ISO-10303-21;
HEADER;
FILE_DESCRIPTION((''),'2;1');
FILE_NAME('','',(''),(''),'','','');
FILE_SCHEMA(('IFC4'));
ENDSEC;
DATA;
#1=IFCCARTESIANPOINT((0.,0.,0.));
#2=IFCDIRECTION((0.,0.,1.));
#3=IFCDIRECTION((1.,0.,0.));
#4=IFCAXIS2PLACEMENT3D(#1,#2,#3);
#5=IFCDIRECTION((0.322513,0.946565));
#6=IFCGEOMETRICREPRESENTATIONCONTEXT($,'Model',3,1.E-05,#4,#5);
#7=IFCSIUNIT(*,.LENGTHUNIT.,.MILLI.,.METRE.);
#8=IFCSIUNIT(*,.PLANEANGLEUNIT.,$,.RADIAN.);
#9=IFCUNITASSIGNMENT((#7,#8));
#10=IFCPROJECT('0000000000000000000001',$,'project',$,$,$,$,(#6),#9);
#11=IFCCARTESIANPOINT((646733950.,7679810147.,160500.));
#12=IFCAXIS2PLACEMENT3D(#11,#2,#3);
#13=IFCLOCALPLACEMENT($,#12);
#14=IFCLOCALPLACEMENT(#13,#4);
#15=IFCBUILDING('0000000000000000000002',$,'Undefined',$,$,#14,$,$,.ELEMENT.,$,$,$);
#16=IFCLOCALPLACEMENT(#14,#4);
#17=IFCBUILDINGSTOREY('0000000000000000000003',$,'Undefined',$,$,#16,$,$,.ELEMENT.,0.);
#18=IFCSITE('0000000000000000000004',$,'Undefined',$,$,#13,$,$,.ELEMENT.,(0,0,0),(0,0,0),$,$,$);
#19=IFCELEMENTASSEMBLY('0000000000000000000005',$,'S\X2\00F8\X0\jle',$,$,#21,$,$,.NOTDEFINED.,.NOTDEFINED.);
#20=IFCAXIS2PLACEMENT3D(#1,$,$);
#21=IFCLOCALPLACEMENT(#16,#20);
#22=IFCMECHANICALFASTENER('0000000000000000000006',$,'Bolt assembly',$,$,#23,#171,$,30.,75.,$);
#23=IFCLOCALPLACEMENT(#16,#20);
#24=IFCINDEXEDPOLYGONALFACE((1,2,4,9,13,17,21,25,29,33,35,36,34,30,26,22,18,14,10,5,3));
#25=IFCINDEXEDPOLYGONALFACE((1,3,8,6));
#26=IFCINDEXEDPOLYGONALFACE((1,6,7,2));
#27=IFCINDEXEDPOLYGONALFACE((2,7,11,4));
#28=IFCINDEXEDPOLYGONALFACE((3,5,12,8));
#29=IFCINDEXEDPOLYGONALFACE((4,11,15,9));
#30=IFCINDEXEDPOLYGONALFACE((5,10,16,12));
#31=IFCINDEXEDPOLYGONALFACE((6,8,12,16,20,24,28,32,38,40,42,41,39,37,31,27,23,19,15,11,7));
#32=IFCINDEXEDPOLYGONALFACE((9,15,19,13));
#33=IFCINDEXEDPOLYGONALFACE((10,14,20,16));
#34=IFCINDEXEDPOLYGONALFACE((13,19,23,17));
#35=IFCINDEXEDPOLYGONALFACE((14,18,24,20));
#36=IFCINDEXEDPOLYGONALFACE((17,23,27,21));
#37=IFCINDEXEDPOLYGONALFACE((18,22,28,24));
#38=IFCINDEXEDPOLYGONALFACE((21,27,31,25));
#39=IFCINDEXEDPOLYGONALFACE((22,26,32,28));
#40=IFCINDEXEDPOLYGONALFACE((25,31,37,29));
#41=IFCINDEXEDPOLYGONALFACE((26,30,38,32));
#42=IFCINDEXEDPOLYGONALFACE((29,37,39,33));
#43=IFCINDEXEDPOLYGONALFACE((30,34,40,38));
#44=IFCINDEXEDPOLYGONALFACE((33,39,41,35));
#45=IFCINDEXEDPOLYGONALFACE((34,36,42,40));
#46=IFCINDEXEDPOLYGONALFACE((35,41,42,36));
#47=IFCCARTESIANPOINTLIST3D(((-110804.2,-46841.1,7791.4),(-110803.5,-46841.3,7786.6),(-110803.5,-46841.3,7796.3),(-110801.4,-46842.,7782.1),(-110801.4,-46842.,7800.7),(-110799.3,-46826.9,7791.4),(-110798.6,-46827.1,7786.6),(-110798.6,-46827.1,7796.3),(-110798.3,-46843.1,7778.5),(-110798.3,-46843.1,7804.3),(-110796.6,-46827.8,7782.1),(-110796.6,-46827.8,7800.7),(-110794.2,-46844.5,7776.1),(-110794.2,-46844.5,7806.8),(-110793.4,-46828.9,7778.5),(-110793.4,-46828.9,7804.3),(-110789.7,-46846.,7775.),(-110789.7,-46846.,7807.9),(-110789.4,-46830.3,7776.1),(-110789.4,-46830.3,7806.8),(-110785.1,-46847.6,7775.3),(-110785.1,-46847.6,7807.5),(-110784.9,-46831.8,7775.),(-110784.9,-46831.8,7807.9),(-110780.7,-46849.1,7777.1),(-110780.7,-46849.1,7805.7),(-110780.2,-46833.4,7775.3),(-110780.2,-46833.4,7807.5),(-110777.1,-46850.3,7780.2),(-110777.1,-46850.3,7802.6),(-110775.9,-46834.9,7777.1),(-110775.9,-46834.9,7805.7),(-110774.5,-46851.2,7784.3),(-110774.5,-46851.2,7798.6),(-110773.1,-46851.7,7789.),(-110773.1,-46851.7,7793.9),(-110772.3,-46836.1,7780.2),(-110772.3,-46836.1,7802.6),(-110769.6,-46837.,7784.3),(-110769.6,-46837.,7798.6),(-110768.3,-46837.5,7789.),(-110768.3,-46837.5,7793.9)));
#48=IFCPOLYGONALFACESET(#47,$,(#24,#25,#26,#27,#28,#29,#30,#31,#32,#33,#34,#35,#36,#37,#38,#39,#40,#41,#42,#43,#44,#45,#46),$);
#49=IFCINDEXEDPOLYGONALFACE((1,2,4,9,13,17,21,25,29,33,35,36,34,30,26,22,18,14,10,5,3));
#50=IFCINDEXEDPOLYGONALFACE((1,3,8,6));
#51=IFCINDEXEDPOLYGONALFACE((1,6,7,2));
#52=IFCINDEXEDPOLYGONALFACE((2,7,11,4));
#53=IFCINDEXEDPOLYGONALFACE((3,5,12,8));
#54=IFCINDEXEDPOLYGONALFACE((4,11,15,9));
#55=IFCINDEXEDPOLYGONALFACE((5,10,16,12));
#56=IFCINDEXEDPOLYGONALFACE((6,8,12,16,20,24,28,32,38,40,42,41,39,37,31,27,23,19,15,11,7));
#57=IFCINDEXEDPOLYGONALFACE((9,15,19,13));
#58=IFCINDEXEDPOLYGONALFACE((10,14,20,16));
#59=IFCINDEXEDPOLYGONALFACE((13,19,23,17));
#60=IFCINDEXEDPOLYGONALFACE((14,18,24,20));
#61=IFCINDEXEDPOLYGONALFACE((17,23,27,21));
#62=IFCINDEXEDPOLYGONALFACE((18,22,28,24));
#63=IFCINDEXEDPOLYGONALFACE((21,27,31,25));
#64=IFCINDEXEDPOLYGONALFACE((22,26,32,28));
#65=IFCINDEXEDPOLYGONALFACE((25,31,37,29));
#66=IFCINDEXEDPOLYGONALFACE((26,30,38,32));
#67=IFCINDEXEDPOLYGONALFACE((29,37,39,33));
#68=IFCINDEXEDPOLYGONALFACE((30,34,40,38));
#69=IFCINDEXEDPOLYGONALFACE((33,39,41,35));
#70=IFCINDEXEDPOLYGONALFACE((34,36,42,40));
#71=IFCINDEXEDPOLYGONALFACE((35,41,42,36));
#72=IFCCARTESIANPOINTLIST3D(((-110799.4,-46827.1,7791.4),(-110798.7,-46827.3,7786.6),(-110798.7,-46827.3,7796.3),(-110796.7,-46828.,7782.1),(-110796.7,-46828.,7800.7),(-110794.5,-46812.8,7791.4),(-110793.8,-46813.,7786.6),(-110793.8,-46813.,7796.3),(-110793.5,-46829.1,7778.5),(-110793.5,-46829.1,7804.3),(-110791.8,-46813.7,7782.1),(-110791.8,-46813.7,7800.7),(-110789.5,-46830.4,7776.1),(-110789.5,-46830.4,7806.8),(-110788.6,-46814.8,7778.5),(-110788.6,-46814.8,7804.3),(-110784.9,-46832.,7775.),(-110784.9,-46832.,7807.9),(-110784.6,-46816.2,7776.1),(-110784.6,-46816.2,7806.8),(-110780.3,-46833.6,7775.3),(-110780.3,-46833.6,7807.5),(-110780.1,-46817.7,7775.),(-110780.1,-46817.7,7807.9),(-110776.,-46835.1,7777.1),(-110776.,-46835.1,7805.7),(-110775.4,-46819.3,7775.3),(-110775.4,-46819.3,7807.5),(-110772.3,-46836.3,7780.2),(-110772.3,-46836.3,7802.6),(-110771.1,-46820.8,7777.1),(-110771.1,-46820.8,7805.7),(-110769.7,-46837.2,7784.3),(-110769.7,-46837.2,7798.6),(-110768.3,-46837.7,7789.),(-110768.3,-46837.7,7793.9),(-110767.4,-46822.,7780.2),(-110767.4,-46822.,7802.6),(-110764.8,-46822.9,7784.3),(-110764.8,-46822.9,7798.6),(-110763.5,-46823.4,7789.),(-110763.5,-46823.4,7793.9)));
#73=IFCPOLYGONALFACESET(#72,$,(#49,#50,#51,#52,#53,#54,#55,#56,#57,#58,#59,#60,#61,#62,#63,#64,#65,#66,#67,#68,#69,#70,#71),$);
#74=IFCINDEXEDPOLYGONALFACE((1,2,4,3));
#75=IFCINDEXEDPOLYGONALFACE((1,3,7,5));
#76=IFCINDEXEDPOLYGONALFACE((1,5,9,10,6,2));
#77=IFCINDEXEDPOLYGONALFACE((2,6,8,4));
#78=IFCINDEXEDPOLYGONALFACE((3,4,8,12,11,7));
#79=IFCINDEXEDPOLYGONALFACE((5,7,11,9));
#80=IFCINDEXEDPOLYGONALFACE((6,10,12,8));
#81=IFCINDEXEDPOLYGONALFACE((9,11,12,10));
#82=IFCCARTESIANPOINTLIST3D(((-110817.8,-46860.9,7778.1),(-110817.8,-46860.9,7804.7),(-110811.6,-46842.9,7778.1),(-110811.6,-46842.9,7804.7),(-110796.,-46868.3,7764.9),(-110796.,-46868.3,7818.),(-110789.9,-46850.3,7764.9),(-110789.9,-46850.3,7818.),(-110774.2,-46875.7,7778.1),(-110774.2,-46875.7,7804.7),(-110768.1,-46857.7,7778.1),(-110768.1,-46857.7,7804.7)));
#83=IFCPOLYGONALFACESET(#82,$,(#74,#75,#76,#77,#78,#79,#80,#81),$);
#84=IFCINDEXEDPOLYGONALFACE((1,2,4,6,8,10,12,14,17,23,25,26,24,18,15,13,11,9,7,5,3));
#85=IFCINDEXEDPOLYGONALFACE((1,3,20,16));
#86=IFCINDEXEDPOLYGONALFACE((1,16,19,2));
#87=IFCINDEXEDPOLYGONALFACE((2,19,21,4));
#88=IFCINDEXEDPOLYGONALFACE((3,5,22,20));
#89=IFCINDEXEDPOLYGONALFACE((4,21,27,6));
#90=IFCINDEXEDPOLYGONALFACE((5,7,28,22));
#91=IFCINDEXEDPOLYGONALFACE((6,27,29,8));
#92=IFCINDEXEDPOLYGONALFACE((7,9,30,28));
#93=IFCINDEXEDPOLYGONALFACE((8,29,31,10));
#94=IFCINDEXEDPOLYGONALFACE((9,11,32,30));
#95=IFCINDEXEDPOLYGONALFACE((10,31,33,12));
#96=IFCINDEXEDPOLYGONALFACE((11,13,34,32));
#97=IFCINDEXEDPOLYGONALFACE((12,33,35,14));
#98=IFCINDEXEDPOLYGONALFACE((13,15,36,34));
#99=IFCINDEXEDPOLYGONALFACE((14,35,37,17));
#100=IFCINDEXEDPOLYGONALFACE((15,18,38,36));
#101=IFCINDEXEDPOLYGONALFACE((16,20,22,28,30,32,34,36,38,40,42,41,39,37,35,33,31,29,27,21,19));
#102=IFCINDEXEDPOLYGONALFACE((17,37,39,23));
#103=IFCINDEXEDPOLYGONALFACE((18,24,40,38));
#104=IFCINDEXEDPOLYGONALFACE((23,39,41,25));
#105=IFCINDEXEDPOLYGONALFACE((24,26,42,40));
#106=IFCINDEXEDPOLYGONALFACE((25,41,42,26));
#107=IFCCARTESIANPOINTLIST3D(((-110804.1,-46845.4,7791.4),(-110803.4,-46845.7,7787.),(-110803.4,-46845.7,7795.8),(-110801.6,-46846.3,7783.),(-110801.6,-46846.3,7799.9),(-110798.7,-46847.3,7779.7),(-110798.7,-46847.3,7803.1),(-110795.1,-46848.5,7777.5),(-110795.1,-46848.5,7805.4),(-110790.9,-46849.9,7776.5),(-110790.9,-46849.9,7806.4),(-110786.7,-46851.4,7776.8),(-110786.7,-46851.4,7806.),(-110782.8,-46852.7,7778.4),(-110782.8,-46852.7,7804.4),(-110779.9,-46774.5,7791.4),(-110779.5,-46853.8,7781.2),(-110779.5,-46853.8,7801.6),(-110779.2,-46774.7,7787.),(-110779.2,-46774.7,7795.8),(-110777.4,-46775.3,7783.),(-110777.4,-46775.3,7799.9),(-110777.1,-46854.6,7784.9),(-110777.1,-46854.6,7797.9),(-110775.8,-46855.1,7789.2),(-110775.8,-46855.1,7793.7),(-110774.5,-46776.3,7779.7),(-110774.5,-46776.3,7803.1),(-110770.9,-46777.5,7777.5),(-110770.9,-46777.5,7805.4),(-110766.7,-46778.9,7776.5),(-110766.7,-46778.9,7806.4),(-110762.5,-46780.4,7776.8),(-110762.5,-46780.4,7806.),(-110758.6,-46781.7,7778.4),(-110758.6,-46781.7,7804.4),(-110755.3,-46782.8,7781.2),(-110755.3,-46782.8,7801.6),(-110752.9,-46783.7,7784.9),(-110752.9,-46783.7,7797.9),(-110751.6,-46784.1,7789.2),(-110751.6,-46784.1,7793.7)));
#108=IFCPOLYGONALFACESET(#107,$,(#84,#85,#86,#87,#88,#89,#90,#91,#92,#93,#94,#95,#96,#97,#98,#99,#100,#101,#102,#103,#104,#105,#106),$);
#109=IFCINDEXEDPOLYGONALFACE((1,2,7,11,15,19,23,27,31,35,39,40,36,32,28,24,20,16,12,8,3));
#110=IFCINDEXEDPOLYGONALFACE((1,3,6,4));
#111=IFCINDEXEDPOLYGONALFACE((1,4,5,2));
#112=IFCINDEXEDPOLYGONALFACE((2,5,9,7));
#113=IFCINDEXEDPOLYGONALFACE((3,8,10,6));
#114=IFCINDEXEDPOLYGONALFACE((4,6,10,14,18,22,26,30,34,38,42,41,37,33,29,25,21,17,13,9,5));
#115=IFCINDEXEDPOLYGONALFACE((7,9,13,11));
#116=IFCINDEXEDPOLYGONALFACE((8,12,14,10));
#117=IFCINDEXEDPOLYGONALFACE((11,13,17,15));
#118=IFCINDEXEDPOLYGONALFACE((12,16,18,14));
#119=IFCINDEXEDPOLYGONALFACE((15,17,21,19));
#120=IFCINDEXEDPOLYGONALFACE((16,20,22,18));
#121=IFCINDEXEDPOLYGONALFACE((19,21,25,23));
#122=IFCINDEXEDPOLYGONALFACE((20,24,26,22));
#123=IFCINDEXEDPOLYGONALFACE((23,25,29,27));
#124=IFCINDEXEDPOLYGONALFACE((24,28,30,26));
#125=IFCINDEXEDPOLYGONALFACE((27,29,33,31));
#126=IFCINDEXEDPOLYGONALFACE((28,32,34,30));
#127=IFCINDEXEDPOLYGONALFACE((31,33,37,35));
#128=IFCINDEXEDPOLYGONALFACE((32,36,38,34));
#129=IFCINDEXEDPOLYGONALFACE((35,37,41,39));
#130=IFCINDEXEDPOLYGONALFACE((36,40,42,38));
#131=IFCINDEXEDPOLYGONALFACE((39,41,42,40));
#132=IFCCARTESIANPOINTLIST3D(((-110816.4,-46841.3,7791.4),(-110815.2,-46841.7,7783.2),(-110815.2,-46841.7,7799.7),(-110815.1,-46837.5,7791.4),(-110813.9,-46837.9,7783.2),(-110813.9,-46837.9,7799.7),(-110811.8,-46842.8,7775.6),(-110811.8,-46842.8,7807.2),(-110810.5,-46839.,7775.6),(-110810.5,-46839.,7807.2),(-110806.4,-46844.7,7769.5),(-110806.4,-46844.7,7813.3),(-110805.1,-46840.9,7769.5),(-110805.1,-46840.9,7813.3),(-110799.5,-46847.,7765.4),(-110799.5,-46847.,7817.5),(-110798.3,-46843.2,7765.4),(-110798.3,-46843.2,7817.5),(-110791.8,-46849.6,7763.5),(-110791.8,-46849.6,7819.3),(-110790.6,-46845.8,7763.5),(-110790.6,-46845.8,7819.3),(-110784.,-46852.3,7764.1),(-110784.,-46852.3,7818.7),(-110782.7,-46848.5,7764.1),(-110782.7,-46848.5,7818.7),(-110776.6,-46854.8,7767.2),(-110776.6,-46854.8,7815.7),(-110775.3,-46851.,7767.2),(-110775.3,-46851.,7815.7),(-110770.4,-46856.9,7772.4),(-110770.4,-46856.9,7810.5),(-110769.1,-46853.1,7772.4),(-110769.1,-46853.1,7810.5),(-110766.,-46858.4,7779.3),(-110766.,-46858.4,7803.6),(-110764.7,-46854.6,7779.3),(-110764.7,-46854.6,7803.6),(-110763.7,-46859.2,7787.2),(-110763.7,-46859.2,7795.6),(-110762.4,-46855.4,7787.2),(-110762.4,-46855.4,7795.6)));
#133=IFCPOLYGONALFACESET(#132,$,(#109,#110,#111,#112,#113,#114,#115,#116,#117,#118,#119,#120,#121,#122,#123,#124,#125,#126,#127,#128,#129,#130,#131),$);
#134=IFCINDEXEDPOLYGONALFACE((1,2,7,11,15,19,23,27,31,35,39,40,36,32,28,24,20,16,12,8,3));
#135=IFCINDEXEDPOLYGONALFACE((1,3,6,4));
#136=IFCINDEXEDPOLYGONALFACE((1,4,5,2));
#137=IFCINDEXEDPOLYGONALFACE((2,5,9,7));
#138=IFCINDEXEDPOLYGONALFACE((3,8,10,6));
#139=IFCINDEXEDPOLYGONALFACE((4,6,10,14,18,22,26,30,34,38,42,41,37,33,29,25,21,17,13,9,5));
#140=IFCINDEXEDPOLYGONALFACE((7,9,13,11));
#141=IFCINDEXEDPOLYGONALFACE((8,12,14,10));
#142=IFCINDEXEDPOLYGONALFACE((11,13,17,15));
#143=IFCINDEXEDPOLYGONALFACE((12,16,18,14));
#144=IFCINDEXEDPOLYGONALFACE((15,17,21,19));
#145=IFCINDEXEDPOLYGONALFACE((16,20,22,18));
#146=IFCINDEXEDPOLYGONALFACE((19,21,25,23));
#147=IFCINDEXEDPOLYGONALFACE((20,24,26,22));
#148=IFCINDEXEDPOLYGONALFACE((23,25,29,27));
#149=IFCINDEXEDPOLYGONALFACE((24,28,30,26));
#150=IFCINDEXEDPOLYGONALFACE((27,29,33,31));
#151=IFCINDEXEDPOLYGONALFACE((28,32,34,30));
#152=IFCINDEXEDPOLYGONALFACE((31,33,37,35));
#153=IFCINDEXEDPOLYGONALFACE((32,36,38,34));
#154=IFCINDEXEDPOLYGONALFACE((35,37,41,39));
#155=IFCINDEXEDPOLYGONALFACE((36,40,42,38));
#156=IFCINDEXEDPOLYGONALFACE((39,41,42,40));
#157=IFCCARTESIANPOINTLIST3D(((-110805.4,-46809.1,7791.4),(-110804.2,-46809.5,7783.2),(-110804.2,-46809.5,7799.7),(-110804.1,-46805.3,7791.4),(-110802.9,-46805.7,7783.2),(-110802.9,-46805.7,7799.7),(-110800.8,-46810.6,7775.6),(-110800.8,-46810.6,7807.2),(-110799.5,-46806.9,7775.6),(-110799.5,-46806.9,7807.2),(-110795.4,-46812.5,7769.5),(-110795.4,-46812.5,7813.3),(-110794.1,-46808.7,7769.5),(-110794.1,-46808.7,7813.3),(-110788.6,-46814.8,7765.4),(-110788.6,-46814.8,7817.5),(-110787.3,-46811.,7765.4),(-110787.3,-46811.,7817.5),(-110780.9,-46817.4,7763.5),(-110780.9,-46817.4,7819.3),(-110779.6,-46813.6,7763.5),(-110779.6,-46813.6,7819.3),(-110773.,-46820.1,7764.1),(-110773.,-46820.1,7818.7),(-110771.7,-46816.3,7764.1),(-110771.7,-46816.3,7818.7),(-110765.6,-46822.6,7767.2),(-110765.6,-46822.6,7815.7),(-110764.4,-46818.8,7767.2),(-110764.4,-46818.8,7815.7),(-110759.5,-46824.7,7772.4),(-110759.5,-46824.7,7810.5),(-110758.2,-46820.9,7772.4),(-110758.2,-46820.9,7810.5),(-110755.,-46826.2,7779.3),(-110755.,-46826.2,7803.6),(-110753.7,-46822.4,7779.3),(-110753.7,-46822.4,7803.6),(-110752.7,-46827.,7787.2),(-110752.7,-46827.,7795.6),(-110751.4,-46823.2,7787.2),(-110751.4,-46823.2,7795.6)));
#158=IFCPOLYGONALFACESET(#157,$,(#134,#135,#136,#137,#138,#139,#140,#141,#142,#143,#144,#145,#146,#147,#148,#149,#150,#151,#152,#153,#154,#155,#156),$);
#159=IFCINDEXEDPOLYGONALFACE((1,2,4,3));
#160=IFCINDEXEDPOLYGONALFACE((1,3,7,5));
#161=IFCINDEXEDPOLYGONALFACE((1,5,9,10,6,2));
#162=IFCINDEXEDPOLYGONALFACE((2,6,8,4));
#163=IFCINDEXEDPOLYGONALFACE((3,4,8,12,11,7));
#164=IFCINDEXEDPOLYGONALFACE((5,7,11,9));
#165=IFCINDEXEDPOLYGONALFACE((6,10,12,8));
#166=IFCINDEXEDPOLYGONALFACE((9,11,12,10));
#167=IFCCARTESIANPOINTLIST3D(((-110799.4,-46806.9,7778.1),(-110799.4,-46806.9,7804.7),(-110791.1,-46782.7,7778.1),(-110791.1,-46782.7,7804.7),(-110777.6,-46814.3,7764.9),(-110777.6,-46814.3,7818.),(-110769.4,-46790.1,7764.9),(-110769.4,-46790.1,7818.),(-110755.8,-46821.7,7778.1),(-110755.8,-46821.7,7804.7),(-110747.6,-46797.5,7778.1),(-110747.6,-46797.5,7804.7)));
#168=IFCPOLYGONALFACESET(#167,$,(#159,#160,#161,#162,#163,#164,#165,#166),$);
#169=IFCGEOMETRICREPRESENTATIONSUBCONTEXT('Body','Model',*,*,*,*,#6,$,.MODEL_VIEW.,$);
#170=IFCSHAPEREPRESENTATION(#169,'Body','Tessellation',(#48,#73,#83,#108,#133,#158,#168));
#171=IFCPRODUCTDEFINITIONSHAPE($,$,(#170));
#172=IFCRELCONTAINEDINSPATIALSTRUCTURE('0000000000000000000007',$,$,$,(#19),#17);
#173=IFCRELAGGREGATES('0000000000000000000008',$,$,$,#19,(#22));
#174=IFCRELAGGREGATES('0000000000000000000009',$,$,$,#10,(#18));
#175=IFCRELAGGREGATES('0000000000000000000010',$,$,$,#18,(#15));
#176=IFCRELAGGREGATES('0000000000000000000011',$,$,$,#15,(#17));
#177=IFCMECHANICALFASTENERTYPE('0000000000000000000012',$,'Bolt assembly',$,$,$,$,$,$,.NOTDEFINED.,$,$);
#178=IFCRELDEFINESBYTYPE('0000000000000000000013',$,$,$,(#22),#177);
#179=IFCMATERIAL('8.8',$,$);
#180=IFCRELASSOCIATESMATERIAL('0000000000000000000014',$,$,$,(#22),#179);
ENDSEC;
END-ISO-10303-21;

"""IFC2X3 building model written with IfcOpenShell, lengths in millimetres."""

from ifc_helpers import new_model, si_unit, direction, frame, origin_with_axes, origin_2d_with_axis, place, context, subcontext, project, spatial, polyline, circle, outline, extrude, source, transform, mapped, material, type_object, element, aggregate, save


model = new_model("IFC2X3")

# Units and contexts
model_context = context("Model", 3, precision=1e-05, world=origin_with_axes(), true_north=direction((0.322513, 0.946565)))
body_context = subcontext(model_context, "Body", "Model", "MODEL_VIEW")
ifc_project = project(units=[si_unit("LENGTHUNIT", "METRE", prefix="MILLI"), si_unit("PLANEANGLEUNIT", "RADIAN")], contexts=[model_context])

# Site, building, storey
site_placement = place(None, frame((646733950.0, 7679810147.0, 160500.0), z_axis=(0.0, 0.0, 1.0), x_axis=(1.0, 0.0, 0.0)))
site = spatial("IfcSite", under=ifc_project, at=site_placement, Name="Undefined", CompositionType="ELEMENT", RefLatitude=(0, 0, 0), RefLongitude=(0, 0, 0))
building_placement = place(site_placement, origin_with_axes())
building = spatial("IfcBuilding", under=site, at=building_placement, Name="Undefined", CompositionType="ELEMENT")
storey_placement = place(building_placement, origin_with_axes())
storey = spatial("IfcBuildingStorey", under=building, at=storey_placement, Name="Undefined", CompositionType="ELEMENT", Elevation=0.0)

# Element assembly
assembly_1_placement = place(storey_placement, origin_with_axes())
assembly_1 = element("IfcElementAssembly", 1, at=assembly_1_placement, inside=storey, Name="Søjle", AssemblyPlace="NOTDEFINED", PredefinedType="NOTDEFINED")

# Mechanical fastener
ifc_material_1 = material(Name="8.8")
mechanical_fastener_type = type_object("IfcMechanicalFastenerType", Name="Bolt assembly")
shared_shape_1 = source(origin_with_axes(), body_context, "Body", "SweptSolid", [
    extrude(circle(Radius=16.5, at=origin_2d_with_axis()), frame((0.0, -7.4, 0.0), z_axis=(0.0, 1.0, 0.0), x_axis=(1.0, 0.0, 0.0)), (0.0, 0.0, 1.0), 15.0),
    extrude(circle(Radius=16.5, at=origin_2d_with_axis()), frame((0.0, 7.4, 0.0), z_axis=(0.0, 1.0, 0.0), x_axis=(1.0, 0.0, 0.0)), (0.0, 0.0, 1.0), 15.1),
    extrude(outline(polyline([(23.0, -13.3), (23.0, 13.3), (0.0, 26.6), (-23.0, 13.3), (-23.0, -13.3), (0.0, -26.6), (23.0, -13.3)])), frame((0.0, -30.5, 0.0), z_axis=(0.0, 1.0, 0.0), x_axis=(1.0, 0.0, 0.0)), (0.0, 0.0, 1.0), 19.0),
    extrude(circle(Radius=15.0, at=origin_2d_with_axis()), frame((0.0, -11.5, 0.0), z_axis=(0.0, 1.0, 0.0), x_axis=(1.0, 0.0, 0.0)), (0.0, 0.0, 1.0), 75.0),
    extrude(circle(Radius=28.0, at=origin_2d_with_axis()), frame((0.0, -11.5, 0.0), z_axis=(0.0, 1.0, 0.0), x_axis=(1.0, 0.0, 0.0)), (0.0, 0.0, 1.0), 4.0),
    extrude(circle(Radius=28.0, at=origin_2d_with_axis()), frame((0.0, 22.5, 0.0), z_axis=(0.0, 1.0, 0.0), x_axis=(1.0, 0.0, 0.0)), (0.0, 0.0, 1.0), 4.0),
    extrude(outline(polyline([(23.0, -13.3), (23.0, 13.3), (0.0, 26.6), (-23.0, 13.3), (-23.0, -13.3), (0.0, -26.6), (23.0, -13.3)])), frame((0.0, 26.5, 0.0), z_axis=(0.0, 1.0, 0.0), x_axis=(1.0, 0.0, 0.0)), (0.0, 0.0, 1.0), 25.6),
])
mechanical_fastener_1_placement = place(assembly_1_placement, frame((-110786.2, -46839.4, 7791.4), z_axis=(0.0, 0.0, -1.0), x_axis=(-0.946565, 0.322513, 0.0)))
mechanical_fastener_1 = element("IfcMechanicalFastener", 2, at=mechanical_fastener_1_placement, type_object=mechanical_fastener_type, material=ifc_material_1, Name="Bolt assembly", NominalDiameter=30.0, NominalLength=75.0, context=body_context, shape_type="MappedRepresentation", body=[
    mapped(shared_shape_1, transform((0.0, 0.0, 0.0))),
])
aggregate(assembly_1, [mechanical_fastener_1])

save(model, "model.ifc")
